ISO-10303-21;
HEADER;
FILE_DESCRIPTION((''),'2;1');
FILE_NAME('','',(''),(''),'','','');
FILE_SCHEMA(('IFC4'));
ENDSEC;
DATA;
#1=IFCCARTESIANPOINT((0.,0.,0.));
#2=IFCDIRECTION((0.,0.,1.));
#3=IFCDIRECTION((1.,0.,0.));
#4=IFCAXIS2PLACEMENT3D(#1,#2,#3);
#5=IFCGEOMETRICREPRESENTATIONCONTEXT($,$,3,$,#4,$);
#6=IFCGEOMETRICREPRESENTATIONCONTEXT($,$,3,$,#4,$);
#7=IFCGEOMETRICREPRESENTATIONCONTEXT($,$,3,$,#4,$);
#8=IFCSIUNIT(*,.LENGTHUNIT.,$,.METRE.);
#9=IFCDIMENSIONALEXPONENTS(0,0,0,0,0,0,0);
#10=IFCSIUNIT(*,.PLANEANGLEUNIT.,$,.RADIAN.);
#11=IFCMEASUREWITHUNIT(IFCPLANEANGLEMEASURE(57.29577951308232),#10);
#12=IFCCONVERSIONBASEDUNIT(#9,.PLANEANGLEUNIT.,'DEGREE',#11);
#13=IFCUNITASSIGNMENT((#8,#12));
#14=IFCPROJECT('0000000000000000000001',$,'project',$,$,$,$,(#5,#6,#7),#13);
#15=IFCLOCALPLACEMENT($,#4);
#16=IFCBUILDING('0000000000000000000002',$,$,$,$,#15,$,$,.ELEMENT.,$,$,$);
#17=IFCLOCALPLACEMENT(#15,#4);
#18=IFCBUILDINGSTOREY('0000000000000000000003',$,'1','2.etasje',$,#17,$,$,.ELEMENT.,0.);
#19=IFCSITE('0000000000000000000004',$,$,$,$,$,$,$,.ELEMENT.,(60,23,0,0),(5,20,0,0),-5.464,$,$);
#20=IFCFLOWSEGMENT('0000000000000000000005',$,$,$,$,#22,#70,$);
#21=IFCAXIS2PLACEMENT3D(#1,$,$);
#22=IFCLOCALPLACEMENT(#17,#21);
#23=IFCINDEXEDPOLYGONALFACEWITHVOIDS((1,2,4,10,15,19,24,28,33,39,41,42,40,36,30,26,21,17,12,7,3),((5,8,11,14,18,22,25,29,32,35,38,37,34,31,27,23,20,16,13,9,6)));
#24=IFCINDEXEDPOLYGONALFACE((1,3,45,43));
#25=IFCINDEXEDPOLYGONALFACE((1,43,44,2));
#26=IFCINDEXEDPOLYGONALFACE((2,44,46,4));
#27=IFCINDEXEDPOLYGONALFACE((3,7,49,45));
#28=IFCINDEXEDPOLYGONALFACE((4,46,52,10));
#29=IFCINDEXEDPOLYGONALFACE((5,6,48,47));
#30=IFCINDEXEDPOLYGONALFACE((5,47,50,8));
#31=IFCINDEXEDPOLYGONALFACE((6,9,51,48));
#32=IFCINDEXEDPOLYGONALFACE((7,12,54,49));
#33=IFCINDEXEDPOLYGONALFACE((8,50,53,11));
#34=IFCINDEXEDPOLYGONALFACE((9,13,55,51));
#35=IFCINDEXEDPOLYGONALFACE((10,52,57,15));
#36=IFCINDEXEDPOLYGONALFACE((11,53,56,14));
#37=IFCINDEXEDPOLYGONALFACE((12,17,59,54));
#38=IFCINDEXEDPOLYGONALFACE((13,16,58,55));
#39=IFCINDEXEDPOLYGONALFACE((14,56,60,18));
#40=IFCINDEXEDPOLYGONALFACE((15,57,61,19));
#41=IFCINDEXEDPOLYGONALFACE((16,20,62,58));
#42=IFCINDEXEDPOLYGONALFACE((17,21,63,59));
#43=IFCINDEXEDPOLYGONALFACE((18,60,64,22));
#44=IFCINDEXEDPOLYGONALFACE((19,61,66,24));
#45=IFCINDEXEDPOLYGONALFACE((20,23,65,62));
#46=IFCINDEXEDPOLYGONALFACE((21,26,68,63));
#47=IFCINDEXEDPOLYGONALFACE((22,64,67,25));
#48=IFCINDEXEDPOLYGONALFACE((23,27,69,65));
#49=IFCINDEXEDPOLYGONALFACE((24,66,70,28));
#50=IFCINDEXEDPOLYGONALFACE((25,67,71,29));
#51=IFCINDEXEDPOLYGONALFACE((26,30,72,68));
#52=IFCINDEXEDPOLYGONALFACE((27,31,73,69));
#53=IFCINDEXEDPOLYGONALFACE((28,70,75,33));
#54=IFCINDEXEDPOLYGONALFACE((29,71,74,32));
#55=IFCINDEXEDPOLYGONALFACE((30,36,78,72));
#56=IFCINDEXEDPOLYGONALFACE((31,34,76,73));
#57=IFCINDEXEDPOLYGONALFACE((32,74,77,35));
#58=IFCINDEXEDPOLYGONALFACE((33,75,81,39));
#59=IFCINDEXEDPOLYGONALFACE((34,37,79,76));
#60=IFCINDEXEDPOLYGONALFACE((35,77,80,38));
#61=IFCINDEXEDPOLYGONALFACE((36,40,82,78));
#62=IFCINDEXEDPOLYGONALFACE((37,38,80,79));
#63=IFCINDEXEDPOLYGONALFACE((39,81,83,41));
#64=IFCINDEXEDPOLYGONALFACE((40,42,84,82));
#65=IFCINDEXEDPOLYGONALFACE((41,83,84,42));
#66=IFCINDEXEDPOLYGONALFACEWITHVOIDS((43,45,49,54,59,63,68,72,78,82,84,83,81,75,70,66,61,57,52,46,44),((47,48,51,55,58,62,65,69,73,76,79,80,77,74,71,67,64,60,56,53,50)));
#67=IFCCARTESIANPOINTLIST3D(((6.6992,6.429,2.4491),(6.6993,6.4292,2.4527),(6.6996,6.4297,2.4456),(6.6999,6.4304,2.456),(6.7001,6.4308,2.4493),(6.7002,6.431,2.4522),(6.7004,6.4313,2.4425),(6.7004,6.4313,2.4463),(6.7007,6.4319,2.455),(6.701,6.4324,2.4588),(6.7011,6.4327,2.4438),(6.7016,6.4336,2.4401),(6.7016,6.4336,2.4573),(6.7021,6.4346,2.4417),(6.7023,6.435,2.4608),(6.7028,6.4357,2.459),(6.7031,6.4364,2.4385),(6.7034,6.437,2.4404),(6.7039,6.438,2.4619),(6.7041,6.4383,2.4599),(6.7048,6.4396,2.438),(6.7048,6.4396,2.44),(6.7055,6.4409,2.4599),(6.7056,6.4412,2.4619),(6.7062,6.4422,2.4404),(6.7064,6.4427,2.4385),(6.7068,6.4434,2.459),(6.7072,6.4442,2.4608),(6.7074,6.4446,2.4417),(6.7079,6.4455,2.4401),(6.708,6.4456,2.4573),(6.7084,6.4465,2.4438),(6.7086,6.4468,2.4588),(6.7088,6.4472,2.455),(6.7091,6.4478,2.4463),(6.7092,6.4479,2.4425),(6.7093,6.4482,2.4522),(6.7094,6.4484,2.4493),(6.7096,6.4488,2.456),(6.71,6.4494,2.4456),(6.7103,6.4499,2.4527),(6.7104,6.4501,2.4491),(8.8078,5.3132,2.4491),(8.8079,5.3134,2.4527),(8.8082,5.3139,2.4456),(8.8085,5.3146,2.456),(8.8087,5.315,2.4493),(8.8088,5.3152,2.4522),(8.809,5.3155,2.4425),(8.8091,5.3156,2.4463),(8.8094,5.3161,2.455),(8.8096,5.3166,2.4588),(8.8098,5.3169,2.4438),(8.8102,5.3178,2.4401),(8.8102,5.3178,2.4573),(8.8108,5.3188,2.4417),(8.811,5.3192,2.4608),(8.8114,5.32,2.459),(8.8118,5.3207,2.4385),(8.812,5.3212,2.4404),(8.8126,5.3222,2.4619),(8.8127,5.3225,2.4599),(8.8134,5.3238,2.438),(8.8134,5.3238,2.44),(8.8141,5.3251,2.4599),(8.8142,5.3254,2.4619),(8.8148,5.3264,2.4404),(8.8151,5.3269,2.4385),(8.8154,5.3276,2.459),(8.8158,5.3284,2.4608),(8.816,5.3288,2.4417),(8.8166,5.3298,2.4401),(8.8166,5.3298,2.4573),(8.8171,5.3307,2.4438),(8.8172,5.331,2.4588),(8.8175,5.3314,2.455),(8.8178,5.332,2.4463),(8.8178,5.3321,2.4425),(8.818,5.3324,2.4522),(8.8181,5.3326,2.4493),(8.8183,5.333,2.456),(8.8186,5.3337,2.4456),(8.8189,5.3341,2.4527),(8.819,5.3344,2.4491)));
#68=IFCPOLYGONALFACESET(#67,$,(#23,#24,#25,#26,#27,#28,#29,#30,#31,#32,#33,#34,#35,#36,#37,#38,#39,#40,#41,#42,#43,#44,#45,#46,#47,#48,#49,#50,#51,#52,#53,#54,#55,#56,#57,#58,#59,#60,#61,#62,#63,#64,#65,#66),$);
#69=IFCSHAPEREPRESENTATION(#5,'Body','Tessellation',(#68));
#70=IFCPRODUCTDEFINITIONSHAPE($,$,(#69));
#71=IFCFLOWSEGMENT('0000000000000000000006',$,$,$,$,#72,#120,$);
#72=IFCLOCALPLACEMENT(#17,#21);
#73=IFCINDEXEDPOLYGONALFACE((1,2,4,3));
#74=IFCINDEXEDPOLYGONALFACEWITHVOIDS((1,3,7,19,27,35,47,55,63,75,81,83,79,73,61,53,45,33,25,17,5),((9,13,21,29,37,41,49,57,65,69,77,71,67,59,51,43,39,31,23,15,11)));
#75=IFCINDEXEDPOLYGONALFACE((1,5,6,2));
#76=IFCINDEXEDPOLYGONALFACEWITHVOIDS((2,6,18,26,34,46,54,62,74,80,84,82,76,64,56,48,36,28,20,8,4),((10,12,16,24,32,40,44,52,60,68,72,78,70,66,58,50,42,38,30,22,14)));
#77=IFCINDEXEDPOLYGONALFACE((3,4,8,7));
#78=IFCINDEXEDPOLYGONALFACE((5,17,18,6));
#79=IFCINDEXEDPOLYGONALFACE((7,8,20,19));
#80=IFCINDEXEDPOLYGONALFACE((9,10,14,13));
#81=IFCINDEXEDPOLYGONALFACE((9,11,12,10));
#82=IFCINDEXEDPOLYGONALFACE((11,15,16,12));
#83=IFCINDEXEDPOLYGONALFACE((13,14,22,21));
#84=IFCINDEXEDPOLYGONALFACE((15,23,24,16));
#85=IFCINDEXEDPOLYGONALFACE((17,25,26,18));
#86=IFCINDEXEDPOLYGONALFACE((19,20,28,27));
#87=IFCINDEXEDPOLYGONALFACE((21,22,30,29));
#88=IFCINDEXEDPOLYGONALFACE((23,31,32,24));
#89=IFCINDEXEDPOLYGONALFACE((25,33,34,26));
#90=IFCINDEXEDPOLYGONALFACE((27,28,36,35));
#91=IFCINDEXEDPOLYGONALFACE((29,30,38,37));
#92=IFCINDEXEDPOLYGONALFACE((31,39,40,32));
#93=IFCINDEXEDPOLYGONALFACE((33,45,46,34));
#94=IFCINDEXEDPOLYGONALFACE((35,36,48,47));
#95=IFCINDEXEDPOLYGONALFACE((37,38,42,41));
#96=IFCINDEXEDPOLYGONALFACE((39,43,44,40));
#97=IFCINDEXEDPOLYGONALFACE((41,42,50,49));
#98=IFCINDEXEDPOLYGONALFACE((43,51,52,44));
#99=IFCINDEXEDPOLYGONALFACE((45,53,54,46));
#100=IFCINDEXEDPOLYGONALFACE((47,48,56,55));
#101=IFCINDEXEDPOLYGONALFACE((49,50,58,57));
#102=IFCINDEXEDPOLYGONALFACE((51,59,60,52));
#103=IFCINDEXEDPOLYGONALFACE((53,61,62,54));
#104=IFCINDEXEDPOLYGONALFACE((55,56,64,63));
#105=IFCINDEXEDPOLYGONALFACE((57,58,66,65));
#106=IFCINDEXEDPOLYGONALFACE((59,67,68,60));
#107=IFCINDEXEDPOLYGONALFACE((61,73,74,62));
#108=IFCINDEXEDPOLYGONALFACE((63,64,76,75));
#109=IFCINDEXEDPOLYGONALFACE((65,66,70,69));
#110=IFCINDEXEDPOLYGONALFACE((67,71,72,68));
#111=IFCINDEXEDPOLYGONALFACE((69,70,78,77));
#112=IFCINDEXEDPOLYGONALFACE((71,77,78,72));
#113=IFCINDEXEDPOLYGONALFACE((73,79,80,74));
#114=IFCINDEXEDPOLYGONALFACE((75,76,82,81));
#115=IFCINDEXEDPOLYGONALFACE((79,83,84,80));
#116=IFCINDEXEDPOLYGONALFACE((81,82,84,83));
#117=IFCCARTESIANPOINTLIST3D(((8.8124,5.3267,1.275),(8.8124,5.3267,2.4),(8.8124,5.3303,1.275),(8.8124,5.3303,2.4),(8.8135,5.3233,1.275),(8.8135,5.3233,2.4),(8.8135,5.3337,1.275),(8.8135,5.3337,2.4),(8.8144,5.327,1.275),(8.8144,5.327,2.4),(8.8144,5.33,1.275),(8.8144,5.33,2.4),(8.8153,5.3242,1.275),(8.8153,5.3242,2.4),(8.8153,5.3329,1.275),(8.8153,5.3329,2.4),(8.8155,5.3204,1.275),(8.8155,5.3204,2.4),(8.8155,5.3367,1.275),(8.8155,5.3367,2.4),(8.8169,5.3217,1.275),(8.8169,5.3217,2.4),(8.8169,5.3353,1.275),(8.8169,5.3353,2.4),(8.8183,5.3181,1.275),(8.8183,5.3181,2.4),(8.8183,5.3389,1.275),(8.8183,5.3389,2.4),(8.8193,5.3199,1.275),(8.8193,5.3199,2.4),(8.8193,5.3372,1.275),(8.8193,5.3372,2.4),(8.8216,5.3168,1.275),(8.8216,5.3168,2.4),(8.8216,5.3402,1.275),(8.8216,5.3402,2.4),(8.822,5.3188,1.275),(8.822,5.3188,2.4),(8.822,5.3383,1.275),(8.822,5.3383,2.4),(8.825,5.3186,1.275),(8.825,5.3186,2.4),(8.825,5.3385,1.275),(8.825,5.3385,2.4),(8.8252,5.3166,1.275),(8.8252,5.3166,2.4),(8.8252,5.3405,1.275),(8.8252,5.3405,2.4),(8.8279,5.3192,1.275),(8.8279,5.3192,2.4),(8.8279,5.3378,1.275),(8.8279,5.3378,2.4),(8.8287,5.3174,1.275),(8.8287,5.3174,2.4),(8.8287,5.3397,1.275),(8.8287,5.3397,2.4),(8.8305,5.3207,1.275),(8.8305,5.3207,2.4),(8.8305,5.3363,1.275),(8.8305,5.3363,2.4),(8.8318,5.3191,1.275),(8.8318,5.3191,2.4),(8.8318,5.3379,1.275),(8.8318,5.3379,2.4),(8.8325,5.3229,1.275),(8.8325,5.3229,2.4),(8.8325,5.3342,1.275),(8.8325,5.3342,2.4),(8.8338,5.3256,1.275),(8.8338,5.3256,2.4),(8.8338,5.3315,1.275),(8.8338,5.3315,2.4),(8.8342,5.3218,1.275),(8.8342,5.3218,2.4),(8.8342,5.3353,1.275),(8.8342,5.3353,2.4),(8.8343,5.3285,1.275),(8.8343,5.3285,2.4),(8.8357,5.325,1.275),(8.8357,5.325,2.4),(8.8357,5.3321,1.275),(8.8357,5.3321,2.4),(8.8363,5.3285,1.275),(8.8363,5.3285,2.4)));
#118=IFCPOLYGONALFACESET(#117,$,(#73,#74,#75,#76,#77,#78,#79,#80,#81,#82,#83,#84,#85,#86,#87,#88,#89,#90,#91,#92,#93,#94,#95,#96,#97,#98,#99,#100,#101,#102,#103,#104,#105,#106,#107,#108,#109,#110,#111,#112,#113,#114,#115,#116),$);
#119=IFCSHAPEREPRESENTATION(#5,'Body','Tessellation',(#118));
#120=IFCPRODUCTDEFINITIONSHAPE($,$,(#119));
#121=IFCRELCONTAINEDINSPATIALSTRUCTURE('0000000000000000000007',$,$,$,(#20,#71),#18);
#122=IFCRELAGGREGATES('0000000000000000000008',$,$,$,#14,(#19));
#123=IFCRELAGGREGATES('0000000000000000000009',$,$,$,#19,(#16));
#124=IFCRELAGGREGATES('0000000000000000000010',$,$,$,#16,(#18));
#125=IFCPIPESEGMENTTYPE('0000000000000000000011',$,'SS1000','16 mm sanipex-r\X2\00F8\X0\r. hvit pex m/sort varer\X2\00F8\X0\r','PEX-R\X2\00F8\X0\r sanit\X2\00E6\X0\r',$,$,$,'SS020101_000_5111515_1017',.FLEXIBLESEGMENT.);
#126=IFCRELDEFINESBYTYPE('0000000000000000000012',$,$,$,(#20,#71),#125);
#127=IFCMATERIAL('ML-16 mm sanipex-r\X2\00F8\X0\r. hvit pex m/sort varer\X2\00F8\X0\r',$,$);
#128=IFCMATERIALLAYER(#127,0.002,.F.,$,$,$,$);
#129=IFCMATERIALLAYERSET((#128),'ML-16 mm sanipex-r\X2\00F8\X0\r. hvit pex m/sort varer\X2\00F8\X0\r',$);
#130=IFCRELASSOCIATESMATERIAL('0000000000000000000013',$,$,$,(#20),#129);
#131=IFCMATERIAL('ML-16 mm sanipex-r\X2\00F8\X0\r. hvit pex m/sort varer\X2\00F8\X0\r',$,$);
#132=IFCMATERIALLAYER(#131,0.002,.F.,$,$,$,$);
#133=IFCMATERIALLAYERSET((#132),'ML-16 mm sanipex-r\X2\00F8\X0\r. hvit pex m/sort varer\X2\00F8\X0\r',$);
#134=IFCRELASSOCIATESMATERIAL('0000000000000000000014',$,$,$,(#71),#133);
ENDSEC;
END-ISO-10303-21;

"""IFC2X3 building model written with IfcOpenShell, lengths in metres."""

from ifc_helpers import new_model, entity, si_unit, converted_unit, frame, origin_with_axes, origin_2d_with_axis, place, context, project, spatial, hollow_circle, extrude, material, layer, layer_set, layer_usage, type_object, element, save


model = new_model("IFC2X3")

# Units and contexts
context_of_model_1 = context(None, 3, world=origin_with_axes())
context_of_model_2 = context(None, 3, world=origin_with_axes())
context_of_model_3 = context(None, 3, world=origin_with_axes())
ifc_project = project(units=[si_unit("LENGTHUNIT", "METRE"), converted_unit("PLANEANGLEUNIT", "DEGREE", entity("IfcPlaneAngleMeasure", 57.29577951308232), si_unit("PLANEANGLEUNIT", "RADIAN"), dimensions=[0, 0, 0, 0, 0, 0, 0])], contexts=[context_of_model_1, context_of_model_2, context_of_model_3])

# Site, building, storey
site = spatial("IfcSite", under=ifc_project, CompositionType="ELEMENT", RefLatitude=(60, 23, 0, 0), RefLongitude=(5, 20, 0, 0), RefElevation=-5.464)
building_placement = place(None, origin_with_axes())
building = spatial("IfcBuilding", under=site, at=building_placement, CompositionType="ELEMENT")
storey_placement = place(building_placement, origin_with_axes())
storey = spatial("IfcBuildingStorey", under=building, at=storey_placement, Name="1", Description="2.etasje", CompositionType="ELEMENT", Elevation=0.0)

# Flow segments
pipe_segment_type_1 = type_object("IfcPipeSegmentType", Name="SS1000", Description="16 mm sanipex-rør. hvit pex m/sort varerør", ApplicableOccurrence="PEX-Rør sanitær", ElementType="SS020101_000_5111515_1017", PredefinedType="FLEXIBLESEGMENT")
ifc_material_1 = material(Name="ML-16 mm sanipex-rør. hvit pex m/sort varerør")
ifc_layer_1 = layer(ifc_material_1, 0.002, ventilated=False)
ifc_layer_set_1 = layer_set([ifc_layer_1], Name="ML-16 mm sanipex-rør. hvit pex m/sort varerør")
ifc_layer_usage_1 = layer_usage(ifc_layer_set_1, "AXIS2", "POSITIVE", 0.0)
flow_segment_1_placement = place(storey_placement, frame((8.8134, 5.3238, 2.45), z_axis=(-0.883883, 0.467708, 0.0), x_axis=(0.0, 0.0, -1.0)))
element("IfcFlowSegment", 1, at=flow_segment_1_placement, inside=storey, type_object=pipe_segment_type_1, material=ifc_layer_usage_1, context=context_of_model_1, shape_type="SweptSolid", body=[
    extrude(hollow_circle(Radius=0.012, WallThickness=0.002, at=origin_2d_with_axis()), origin_with_axes(), (0.0, 0.0, 1.0), 2.3856),
])
ifc_material_2 = material(Name="ML-16 mm sanipex-rør. hvit pex m/sort varerør")
ifc_layer_2 = layer(ifc_material_2, 0.002, ventilated=False)
ifc_layer_set_2 = layer_set([ifc_layer_2], Name="ML-16 mm sanipex-rør. hvit pex m/sort varerør")
ifc_layer_usage_2 = layer_usage(ifc_layer_set_2, "AXIS2", "POSITIVE", 0.0)
flow_segment_2_placement = place(storey_placement, frame((8.8243, 5.3285, 1.275), z_axis=(0.0, 0.0, 1.0), x_axis=(1.0, 0.0, 0.0)))
element("IfcFlowSegment", 2, at=flow_segment_2_placement, inside=storey, type_object=pipe_segment_type_1, material=ifc_layer_usage_2, context=context_of_model_1, shape_type="SweptSolid", body=[
    extrude(hollow_circle(Radius=0.012, WallThickness=0.002, at=origin_2d_with_axis()), origin_with_axes(), (0.0, 0.0, 1.0), 1.125),
])

save(model, "model.ifc")
